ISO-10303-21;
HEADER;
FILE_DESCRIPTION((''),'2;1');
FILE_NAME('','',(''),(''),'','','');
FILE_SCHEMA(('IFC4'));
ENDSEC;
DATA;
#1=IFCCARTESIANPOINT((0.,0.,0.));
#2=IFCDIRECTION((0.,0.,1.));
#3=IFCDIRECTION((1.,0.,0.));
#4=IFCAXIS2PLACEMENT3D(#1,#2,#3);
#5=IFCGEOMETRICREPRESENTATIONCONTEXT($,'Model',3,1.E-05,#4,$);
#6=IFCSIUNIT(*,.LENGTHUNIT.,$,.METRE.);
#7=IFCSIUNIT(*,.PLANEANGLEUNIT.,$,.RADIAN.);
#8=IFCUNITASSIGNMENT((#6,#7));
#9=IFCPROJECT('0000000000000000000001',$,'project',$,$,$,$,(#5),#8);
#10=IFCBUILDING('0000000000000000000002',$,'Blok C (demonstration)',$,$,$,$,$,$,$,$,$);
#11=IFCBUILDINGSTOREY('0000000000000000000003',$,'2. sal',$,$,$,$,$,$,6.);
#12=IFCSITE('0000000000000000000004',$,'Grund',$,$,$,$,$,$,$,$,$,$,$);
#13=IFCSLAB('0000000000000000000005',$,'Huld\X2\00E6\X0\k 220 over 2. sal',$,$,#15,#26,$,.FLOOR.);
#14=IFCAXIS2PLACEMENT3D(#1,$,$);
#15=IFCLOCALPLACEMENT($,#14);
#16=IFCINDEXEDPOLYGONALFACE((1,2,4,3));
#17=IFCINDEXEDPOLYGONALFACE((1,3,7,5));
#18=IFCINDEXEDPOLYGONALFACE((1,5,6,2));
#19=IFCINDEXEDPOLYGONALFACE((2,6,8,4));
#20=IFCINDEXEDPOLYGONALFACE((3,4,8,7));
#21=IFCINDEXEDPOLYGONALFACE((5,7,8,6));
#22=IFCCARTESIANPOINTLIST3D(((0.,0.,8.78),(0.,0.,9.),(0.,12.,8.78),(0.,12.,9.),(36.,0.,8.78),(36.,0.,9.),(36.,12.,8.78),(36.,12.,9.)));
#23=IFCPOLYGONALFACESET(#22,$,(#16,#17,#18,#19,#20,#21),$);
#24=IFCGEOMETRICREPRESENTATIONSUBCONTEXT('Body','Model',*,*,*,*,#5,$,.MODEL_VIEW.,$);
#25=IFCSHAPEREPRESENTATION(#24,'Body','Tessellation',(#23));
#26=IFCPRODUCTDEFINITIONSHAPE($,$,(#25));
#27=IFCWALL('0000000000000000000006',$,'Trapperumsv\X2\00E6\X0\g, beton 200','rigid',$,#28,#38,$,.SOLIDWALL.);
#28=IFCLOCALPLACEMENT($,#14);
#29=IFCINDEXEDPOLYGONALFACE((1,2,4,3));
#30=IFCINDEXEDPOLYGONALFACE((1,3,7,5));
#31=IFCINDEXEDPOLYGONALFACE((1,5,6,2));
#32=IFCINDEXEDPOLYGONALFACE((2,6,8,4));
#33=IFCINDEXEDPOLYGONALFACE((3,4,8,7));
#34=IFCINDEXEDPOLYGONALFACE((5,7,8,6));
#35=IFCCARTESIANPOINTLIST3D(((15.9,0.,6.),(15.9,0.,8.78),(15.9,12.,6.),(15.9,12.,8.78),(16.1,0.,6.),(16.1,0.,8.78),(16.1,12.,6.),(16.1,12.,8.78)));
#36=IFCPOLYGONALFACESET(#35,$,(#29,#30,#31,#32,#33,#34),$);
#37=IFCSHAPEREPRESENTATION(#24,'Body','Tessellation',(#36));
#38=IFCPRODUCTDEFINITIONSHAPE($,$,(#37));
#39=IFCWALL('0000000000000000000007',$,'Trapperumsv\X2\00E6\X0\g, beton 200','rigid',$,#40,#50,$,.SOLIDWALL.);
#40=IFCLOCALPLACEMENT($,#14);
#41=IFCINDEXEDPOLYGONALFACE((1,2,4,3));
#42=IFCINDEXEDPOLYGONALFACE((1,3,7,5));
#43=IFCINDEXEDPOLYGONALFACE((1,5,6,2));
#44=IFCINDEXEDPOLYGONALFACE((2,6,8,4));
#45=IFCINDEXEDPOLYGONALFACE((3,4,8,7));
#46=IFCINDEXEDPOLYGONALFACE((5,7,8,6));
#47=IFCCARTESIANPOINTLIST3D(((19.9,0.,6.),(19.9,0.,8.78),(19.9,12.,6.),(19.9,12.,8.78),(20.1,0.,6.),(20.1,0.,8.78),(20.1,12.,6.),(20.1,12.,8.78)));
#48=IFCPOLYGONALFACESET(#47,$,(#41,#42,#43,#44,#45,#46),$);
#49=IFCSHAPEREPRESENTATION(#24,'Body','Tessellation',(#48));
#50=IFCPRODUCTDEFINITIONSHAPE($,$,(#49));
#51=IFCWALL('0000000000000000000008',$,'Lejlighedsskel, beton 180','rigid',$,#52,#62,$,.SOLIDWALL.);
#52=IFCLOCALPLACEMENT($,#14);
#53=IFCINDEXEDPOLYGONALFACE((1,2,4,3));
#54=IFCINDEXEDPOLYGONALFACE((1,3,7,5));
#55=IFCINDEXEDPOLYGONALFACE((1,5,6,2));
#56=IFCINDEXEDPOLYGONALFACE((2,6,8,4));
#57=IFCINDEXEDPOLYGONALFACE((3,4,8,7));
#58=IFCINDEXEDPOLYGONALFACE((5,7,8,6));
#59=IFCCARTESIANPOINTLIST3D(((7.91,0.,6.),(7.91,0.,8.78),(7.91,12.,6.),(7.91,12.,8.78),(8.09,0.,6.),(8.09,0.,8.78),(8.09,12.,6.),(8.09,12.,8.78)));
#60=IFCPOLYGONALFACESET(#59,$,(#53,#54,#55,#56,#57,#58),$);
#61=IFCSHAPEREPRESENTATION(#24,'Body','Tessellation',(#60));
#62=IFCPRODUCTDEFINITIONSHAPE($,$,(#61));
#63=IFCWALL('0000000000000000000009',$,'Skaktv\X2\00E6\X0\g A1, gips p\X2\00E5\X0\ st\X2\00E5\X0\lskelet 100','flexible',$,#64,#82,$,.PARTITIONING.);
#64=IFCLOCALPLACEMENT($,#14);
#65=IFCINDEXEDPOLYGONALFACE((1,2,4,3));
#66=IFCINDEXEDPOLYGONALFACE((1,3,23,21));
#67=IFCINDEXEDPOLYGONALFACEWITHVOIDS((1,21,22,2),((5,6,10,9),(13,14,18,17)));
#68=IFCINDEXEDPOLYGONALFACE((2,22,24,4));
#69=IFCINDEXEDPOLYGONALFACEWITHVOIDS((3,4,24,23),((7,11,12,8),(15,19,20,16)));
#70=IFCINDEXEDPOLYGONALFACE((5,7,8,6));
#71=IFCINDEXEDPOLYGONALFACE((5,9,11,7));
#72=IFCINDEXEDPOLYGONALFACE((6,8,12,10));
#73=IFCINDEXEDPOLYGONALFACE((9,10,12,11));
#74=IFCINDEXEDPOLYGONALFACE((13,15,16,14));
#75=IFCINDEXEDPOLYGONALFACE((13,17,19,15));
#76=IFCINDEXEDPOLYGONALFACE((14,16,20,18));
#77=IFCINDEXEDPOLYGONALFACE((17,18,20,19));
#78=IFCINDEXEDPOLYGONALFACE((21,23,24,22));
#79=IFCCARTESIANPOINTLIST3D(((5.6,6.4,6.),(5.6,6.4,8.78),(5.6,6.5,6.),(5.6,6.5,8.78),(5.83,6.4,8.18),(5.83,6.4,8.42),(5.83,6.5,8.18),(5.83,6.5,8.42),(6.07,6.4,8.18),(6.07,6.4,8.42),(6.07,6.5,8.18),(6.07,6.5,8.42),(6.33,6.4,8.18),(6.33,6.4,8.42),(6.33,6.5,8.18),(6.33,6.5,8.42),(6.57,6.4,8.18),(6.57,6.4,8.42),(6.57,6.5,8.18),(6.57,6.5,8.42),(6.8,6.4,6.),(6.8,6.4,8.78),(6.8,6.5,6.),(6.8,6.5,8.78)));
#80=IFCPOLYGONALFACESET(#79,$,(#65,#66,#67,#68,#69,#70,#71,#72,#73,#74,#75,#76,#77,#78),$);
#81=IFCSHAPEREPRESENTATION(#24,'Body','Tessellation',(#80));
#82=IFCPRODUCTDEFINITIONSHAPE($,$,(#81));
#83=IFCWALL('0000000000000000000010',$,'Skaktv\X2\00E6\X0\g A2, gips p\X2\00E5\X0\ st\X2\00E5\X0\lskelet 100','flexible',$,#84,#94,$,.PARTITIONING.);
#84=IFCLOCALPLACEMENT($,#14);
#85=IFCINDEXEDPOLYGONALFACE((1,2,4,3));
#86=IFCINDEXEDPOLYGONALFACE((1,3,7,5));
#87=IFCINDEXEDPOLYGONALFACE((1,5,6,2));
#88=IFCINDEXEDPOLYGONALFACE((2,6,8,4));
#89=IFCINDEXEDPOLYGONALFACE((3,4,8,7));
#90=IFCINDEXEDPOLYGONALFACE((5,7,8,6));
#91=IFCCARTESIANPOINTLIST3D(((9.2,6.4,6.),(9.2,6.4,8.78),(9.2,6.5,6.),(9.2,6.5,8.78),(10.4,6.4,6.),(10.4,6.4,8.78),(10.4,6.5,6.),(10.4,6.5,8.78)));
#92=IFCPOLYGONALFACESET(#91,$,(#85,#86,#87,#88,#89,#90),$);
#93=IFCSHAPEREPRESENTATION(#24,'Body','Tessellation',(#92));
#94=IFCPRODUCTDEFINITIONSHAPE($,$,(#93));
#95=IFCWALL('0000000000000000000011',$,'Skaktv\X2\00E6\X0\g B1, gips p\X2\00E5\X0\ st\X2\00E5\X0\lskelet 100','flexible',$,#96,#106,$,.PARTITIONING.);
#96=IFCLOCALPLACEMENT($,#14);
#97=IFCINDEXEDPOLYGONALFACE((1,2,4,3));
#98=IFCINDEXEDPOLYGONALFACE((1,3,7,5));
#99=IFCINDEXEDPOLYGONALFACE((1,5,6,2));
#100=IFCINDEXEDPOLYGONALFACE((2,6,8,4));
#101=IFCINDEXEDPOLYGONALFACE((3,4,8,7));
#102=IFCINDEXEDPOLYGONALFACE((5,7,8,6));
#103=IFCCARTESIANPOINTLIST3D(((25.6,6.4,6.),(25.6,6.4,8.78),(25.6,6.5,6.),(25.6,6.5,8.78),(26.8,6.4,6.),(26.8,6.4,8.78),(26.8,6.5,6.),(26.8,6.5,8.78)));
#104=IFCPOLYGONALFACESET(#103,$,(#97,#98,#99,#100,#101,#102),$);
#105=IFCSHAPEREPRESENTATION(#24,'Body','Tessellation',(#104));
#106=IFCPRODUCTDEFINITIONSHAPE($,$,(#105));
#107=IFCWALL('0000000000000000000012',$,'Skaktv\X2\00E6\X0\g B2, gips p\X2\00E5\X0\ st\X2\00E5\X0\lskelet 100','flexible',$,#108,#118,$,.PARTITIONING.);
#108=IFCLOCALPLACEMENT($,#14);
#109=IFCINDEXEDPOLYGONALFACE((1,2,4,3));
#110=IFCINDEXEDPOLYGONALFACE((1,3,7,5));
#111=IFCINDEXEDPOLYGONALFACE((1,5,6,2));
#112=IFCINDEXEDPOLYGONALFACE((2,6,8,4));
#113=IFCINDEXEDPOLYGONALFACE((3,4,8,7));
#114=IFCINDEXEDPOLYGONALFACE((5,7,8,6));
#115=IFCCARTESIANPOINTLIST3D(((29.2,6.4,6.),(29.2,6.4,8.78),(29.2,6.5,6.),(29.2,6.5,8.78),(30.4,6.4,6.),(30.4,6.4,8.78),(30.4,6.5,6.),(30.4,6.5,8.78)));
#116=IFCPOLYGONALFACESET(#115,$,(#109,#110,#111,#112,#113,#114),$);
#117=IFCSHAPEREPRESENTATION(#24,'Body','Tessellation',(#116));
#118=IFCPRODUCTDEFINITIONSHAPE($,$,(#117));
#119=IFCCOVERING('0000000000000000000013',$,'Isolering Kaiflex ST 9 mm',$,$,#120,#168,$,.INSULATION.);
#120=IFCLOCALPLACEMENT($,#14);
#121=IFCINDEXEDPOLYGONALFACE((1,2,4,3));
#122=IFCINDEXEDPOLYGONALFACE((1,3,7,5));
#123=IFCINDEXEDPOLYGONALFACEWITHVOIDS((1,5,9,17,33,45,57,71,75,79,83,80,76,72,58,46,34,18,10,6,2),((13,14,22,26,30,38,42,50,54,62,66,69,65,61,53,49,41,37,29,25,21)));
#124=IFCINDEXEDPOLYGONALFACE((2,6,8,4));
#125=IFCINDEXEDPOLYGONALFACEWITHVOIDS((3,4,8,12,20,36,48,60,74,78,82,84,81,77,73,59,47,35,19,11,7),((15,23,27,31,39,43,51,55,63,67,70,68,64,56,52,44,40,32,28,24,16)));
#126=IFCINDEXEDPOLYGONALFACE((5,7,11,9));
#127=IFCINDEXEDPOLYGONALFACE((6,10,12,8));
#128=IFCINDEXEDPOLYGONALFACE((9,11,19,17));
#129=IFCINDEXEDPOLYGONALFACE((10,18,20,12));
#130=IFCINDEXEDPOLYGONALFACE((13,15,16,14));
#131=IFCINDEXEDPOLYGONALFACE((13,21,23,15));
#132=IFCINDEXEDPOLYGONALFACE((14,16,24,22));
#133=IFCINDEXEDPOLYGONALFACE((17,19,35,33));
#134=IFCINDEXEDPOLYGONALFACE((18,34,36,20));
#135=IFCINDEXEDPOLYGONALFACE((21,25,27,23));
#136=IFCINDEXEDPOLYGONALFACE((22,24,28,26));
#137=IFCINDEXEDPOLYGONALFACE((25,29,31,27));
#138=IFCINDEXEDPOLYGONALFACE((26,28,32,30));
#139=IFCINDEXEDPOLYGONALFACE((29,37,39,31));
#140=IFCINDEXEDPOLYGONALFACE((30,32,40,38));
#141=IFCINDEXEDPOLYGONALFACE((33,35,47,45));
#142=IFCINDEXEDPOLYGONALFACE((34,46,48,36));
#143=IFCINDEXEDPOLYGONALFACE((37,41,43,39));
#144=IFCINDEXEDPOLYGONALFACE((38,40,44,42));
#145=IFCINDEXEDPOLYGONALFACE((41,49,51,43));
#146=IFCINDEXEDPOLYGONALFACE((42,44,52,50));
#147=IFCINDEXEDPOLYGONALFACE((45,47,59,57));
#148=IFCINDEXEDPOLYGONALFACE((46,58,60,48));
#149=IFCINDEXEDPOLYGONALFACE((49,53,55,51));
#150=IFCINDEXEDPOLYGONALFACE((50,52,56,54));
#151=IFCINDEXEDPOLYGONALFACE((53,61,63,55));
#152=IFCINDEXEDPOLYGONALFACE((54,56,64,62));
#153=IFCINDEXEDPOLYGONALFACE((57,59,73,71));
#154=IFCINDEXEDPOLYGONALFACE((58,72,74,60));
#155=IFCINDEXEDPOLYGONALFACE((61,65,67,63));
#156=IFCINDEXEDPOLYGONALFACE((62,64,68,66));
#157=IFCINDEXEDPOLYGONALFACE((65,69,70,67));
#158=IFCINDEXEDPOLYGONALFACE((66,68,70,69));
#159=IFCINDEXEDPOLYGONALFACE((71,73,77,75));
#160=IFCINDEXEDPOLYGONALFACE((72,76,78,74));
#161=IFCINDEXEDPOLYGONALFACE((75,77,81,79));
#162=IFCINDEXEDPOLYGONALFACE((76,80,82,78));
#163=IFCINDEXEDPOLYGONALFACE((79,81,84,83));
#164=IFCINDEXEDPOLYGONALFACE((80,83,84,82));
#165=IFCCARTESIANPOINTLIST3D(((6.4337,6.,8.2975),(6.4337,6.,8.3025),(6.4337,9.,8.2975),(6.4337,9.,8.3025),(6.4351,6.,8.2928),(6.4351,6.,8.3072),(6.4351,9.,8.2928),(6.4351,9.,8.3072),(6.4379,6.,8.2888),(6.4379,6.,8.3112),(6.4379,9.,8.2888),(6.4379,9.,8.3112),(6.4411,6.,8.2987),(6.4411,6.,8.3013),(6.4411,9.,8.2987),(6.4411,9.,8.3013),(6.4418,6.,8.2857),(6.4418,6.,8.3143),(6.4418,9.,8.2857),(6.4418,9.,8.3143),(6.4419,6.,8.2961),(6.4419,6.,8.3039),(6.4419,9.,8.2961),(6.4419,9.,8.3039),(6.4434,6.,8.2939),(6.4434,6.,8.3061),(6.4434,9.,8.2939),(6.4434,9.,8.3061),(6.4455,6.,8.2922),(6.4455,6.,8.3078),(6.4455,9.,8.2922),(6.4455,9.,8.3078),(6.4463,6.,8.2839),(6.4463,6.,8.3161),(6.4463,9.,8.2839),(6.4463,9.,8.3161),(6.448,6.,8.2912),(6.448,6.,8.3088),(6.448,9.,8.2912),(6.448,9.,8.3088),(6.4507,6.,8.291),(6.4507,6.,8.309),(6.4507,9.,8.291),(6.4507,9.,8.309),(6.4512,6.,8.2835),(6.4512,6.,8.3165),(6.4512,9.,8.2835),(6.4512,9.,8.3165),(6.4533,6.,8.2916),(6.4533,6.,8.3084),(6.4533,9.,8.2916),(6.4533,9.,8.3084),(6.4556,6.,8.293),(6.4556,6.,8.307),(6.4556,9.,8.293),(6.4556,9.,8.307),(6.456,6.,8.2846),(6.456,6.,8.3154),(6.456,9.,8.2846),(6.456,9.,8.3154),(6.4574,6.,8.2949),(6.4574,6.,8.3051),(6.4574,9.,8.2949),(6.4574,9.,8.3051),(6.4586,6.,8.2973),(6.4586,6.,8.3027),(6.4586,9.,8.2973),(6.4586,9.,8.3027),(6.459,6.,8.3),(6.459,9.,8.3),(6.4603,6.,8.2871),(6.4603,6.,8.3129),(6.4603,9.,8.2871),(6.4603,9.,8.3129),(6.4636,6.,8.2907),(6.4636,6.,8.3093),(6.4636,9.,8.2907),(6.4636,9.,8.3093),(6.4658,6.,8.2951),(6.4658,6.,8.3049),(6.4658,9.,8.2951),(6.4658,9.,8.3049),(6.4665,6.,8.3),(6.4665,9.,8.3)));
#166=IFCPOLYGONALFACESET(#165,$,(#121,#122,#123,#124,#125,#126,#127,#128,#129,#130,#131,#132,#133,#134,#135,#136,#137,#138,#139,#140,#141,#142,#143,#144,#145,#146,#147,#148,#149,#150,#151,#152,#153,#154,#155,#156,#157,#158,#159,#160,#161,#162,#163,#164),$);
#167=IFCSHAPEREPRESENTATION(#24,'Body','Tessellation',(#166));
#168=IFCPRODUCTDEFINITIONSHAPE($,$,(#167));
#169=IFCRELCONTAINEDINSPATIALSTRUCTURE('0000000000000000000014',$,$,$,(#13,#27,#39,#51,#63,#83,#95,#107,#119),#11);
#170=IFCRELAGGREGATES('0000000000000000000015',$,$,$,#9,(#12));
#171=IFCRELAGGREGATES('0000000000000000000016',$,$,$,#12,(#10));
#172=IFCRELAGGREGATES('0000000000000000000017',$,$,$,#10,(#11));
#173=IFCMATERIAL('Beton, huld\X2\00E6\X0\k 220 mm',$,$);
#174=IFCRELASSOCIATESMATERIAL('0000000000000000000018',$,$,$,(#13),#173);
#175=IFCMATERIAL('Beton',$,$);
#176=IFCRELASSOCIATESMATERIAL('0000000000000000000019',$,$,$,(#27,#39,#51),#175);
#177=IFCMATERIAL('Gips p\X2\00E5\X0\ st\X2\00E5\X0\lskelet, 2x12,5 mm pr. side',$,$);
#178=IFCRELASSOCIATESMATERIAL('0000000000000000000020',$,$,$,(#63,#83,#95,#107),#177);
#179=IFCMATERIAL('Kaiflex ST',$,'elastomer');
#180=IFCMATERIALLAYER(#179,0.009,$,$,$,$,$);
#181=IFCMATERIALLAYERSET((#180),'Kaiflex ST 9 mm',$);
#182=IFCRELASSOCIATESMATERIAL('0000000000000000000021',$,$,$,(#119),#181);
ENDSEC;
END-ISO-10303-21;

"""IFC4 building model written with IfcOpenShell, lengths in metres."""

from ifc_helpers import new_model, si_unit, frame, origin_with_axes, place, context, subcontext, project, spatial, polyline, hollow_circle, outline, extrude, material, layer, layer_set, element, save


model = new_model("IFC4")

# Units and contexts
model_context = context("Model", 3, precision=1e-05, world=origin_with_axes())
body_context = subcontext(model_context, "Body", "Model", "MODEL_VIEW")
ifc_project = project(units=[si_unit("LENGTHUNIT", "METRE"), si_unit("PLANEANGLEUNIT", "RADIAN")], contexts=[model_context])

# Site, building, storey
site = spatial("IfcSite", under=ifc_project, Name="Grund")
building = spatial("IfcBuilding", under=site, Name="Blok C (demonstration)")
storey = spatial("IfcBuildingStorey", under=building, Name="2. sal", Elevation=6.0)

# Slab
ifc_material_1 = material(Name="Beton, huldæk 220 mm")
slab_placement = place(None, origin_with_axes())
element("IfcSlab", 1, at=slab_placement, inside=storey, material=ifc_material_1, Name="Huldæk 220 over 2. sal", PredefinedType="FLOOR", context=body_context, shape_type="SweptSolid", body=[
    extrude(outline(polyline([(0.0, 0.0), (36.0, 0.0), (36.0, 12.0), (0.0, 12.0), (0.0, 0.0)])), frame((0.0, 0.0, 8.78)), (0.0, 0.0, 1.0), 0.22),
])

# Walls
ifc_material_2 = material(Name="Beton")
wall_1_placement = place(None, origin_with_axes())
element("IfcWall", 2, at=wall_1_placement, inside=storey, material=ifc_material_2, Name="Trapperumsvæg, beton 200", Description="rigid", PredefinedType="SOLIDWALL", context=body_context, shape_type="SweptSolid", body=[
    extrude(outline(polyline([(15.9, 0.0), (16.1, 0.0), (16.1, 12.0), (15.9, 12.0), (15.9, 0.0)])), frame((0.0, 0.0, 6.0)), (0.0, 0.0, 1.0), 2.78),
])
wall_2_placement = place(None, origin_with_axes())
element("IfcWall", 3, at=wall_2_placement, inside=storey, material=ifc_material_2, Name="Trapperumsvæg, beton 200", Description="rigid", PredefinedType="SOLIDWALL", context=body_context, shape_type="SweptSolid", body=[
    extrude(outline(polyline([(19.9, 0.0), (20.1, 0.0), (20.1, 12.0), (19.9, 12.0), (19.9, 0.0)])), frame((0.0, 0.0, 6.0)), (0.0, 0.0, 1.0), 2.78),
])
wall_3_placement = place(None, origin_with_axes())
element("IfcWall", 4, at=wall_3_placement, inside=storey, material=ifc_material_2, Name="Lejlighedsskel, beton 180", Description="rigid", PredefinedType="SOLIDWALL", context=body_context, shape_type="SweptSolid", body=[
    extrude(outline(polyline([(7.91, 0.0), (8.09, 0.0), (8.09, 12.0), (7.91, 12.0), (7.91, 0.0)])), frame((0.0, 0.0, 6.0)), (0.0, 0.0, 1.0), 2.78),
])

# Wall, openings
ifc_material_3 = material(Name="Gips på stålskelet, 2x12,5 mm pr. side")
wall_4_placement = place(None, origin_with_axes())
wall_4 = element("IfcWall", 5, at=wall_4_placement, inside=storey, material=ifc_material_3, Name="Skaktvæg A1, gips på stålskelet 100", Description="flexible", PredefinedType="PARTITIONING", context=body_context, shape_type="SweptSolid", body=[
    extrude(outline(polyline([(5.6, 6.4), (6.8, 6.4), (6.8, 6.5), (5.6, 6.5), (5.6, 6.4)])), frame((0.0, 0.0, 6.0)), (0.0, 0.0, 1.0), 2.78),
])
opening_1_placement = place(wall_4_placement, origin_with_axes())
element("IfcOpeningElement", 6, at=opening_1_placement, cuts=wall_4, PredefinedType="OPENING", context=body_context, shape_type="SweptSolid", body=[
    extrude(outline(polyline([(5.83, 6.33), (6.07, 6.33), (6.07, 6.57), (5.83, 6.57), (5.83, 6.33)])), frame((0.0, 0.0, 8.18)), (0.0, 0.0, 1.0), 0.24),
])
opening_2_placement = place(wall_4_placement, origin_with_axes())
element("IfcOpeningElement", 7, at=opening_2_placement, cuts=wall_4, PredefinedType="OPENING", context=body_context, shape_type="SweptSolid", body=[
    extrude(outline(polyline([(6.33, 6.33), (6.57, 6.33), (6.57, 6.57), (6.33, 6.57), (6.33, 6.33)])), frame((0.0, 0.0, 8.18)), (0.0, 0.0, 1.0), 0.24),
])

# Walls
wall_5_placement = place(None, origin_with_axes())
element("IfcWall", 8, at=wall_5_placement, inside=storey, material=ifc_material_3, Name="Skaktvæg A2, gips på stålskelet 100", Description="flexible", PredefinedType="PARTITIONING", context=body_context, shape_type="SweptSolid", body=[
    extrude(outline(polyline([(9.2, 6.4), (10.4, 6.4), (10.4, 6.5), (9.2, 6.5), (9.2, 6.4)])), frame((0.0, 0.0, 6.0)), (0.0, 0.0, 1.0), 2.78),
])
wall_6_placement = place(None, origin_with_axes())
element("IfcWall", 9, at=wall_6_placement, inside=storey, material=ifc_material_3, Name="Skaktvæg B1, gips på stålskelet 100", Description="flexible", PredefinedType="PARTITIONING", context=body_context, shape_type="SweptSolid", body=[
    extrude(outline(polyline([(25.6, 6.4), (26.8, 6.4), (26.8, 6.5), (25.6, 6.5), (25.6, 6.4)])), frame((0.0, 0.0, 6.0)), (0.0, 0.0, 1.0), 2.78),
])
wall_7_placement = place(None, origin_with_axes())
element("IfcWall", 10, at=wall_7_placement, inside=storey, material=ifc_material_3, Name="Skaktvæg B2, gips på stålskelet 100", Description="flexible", PredefinedType="PARTITIONING", context=body_context, shape_type="SweptSolid", body=[
    extrude(outline(polyline([(29.2, 6.4), (30.4, 6.4), (30.4, 6.5), (29.2, 6.5), (29.2, 6.4)])), frame((0.0, 0.0, 6.0)), (0.0, 0.0, 1.0), 2.78),
])

# Covering
ifc_material_4 = material(Name="Kaiflex ST", Category="elastomer")
ifc_layer = layer(ifc_material_4, 0.009)
ifc_layer_set = layer_set([ifc_layer], Name="Kaiflex ST 9 mm")
covering_placement = place(None, origin_with_axes())
element("IfcCovering", 11, at=covering_placement, inside=storey, material=ifc_layer_set, Name="Isolering Kaiflex ST 9 mm", PredefinedType="INSULATION", context=body_context, shape_type="SweptSolid", body=[
    extrude(hollow_circle(Radius=0.0165, WallThickness=0.0075), frame((6.45, 6.0, 8.3), z_axis=(0.0, 1.0, 0.0), x_axis=(1.0, 0.0, 0.0)), (0.0, 0.0, 1.0), 3.0),
])

save(model, "model.ifc")
